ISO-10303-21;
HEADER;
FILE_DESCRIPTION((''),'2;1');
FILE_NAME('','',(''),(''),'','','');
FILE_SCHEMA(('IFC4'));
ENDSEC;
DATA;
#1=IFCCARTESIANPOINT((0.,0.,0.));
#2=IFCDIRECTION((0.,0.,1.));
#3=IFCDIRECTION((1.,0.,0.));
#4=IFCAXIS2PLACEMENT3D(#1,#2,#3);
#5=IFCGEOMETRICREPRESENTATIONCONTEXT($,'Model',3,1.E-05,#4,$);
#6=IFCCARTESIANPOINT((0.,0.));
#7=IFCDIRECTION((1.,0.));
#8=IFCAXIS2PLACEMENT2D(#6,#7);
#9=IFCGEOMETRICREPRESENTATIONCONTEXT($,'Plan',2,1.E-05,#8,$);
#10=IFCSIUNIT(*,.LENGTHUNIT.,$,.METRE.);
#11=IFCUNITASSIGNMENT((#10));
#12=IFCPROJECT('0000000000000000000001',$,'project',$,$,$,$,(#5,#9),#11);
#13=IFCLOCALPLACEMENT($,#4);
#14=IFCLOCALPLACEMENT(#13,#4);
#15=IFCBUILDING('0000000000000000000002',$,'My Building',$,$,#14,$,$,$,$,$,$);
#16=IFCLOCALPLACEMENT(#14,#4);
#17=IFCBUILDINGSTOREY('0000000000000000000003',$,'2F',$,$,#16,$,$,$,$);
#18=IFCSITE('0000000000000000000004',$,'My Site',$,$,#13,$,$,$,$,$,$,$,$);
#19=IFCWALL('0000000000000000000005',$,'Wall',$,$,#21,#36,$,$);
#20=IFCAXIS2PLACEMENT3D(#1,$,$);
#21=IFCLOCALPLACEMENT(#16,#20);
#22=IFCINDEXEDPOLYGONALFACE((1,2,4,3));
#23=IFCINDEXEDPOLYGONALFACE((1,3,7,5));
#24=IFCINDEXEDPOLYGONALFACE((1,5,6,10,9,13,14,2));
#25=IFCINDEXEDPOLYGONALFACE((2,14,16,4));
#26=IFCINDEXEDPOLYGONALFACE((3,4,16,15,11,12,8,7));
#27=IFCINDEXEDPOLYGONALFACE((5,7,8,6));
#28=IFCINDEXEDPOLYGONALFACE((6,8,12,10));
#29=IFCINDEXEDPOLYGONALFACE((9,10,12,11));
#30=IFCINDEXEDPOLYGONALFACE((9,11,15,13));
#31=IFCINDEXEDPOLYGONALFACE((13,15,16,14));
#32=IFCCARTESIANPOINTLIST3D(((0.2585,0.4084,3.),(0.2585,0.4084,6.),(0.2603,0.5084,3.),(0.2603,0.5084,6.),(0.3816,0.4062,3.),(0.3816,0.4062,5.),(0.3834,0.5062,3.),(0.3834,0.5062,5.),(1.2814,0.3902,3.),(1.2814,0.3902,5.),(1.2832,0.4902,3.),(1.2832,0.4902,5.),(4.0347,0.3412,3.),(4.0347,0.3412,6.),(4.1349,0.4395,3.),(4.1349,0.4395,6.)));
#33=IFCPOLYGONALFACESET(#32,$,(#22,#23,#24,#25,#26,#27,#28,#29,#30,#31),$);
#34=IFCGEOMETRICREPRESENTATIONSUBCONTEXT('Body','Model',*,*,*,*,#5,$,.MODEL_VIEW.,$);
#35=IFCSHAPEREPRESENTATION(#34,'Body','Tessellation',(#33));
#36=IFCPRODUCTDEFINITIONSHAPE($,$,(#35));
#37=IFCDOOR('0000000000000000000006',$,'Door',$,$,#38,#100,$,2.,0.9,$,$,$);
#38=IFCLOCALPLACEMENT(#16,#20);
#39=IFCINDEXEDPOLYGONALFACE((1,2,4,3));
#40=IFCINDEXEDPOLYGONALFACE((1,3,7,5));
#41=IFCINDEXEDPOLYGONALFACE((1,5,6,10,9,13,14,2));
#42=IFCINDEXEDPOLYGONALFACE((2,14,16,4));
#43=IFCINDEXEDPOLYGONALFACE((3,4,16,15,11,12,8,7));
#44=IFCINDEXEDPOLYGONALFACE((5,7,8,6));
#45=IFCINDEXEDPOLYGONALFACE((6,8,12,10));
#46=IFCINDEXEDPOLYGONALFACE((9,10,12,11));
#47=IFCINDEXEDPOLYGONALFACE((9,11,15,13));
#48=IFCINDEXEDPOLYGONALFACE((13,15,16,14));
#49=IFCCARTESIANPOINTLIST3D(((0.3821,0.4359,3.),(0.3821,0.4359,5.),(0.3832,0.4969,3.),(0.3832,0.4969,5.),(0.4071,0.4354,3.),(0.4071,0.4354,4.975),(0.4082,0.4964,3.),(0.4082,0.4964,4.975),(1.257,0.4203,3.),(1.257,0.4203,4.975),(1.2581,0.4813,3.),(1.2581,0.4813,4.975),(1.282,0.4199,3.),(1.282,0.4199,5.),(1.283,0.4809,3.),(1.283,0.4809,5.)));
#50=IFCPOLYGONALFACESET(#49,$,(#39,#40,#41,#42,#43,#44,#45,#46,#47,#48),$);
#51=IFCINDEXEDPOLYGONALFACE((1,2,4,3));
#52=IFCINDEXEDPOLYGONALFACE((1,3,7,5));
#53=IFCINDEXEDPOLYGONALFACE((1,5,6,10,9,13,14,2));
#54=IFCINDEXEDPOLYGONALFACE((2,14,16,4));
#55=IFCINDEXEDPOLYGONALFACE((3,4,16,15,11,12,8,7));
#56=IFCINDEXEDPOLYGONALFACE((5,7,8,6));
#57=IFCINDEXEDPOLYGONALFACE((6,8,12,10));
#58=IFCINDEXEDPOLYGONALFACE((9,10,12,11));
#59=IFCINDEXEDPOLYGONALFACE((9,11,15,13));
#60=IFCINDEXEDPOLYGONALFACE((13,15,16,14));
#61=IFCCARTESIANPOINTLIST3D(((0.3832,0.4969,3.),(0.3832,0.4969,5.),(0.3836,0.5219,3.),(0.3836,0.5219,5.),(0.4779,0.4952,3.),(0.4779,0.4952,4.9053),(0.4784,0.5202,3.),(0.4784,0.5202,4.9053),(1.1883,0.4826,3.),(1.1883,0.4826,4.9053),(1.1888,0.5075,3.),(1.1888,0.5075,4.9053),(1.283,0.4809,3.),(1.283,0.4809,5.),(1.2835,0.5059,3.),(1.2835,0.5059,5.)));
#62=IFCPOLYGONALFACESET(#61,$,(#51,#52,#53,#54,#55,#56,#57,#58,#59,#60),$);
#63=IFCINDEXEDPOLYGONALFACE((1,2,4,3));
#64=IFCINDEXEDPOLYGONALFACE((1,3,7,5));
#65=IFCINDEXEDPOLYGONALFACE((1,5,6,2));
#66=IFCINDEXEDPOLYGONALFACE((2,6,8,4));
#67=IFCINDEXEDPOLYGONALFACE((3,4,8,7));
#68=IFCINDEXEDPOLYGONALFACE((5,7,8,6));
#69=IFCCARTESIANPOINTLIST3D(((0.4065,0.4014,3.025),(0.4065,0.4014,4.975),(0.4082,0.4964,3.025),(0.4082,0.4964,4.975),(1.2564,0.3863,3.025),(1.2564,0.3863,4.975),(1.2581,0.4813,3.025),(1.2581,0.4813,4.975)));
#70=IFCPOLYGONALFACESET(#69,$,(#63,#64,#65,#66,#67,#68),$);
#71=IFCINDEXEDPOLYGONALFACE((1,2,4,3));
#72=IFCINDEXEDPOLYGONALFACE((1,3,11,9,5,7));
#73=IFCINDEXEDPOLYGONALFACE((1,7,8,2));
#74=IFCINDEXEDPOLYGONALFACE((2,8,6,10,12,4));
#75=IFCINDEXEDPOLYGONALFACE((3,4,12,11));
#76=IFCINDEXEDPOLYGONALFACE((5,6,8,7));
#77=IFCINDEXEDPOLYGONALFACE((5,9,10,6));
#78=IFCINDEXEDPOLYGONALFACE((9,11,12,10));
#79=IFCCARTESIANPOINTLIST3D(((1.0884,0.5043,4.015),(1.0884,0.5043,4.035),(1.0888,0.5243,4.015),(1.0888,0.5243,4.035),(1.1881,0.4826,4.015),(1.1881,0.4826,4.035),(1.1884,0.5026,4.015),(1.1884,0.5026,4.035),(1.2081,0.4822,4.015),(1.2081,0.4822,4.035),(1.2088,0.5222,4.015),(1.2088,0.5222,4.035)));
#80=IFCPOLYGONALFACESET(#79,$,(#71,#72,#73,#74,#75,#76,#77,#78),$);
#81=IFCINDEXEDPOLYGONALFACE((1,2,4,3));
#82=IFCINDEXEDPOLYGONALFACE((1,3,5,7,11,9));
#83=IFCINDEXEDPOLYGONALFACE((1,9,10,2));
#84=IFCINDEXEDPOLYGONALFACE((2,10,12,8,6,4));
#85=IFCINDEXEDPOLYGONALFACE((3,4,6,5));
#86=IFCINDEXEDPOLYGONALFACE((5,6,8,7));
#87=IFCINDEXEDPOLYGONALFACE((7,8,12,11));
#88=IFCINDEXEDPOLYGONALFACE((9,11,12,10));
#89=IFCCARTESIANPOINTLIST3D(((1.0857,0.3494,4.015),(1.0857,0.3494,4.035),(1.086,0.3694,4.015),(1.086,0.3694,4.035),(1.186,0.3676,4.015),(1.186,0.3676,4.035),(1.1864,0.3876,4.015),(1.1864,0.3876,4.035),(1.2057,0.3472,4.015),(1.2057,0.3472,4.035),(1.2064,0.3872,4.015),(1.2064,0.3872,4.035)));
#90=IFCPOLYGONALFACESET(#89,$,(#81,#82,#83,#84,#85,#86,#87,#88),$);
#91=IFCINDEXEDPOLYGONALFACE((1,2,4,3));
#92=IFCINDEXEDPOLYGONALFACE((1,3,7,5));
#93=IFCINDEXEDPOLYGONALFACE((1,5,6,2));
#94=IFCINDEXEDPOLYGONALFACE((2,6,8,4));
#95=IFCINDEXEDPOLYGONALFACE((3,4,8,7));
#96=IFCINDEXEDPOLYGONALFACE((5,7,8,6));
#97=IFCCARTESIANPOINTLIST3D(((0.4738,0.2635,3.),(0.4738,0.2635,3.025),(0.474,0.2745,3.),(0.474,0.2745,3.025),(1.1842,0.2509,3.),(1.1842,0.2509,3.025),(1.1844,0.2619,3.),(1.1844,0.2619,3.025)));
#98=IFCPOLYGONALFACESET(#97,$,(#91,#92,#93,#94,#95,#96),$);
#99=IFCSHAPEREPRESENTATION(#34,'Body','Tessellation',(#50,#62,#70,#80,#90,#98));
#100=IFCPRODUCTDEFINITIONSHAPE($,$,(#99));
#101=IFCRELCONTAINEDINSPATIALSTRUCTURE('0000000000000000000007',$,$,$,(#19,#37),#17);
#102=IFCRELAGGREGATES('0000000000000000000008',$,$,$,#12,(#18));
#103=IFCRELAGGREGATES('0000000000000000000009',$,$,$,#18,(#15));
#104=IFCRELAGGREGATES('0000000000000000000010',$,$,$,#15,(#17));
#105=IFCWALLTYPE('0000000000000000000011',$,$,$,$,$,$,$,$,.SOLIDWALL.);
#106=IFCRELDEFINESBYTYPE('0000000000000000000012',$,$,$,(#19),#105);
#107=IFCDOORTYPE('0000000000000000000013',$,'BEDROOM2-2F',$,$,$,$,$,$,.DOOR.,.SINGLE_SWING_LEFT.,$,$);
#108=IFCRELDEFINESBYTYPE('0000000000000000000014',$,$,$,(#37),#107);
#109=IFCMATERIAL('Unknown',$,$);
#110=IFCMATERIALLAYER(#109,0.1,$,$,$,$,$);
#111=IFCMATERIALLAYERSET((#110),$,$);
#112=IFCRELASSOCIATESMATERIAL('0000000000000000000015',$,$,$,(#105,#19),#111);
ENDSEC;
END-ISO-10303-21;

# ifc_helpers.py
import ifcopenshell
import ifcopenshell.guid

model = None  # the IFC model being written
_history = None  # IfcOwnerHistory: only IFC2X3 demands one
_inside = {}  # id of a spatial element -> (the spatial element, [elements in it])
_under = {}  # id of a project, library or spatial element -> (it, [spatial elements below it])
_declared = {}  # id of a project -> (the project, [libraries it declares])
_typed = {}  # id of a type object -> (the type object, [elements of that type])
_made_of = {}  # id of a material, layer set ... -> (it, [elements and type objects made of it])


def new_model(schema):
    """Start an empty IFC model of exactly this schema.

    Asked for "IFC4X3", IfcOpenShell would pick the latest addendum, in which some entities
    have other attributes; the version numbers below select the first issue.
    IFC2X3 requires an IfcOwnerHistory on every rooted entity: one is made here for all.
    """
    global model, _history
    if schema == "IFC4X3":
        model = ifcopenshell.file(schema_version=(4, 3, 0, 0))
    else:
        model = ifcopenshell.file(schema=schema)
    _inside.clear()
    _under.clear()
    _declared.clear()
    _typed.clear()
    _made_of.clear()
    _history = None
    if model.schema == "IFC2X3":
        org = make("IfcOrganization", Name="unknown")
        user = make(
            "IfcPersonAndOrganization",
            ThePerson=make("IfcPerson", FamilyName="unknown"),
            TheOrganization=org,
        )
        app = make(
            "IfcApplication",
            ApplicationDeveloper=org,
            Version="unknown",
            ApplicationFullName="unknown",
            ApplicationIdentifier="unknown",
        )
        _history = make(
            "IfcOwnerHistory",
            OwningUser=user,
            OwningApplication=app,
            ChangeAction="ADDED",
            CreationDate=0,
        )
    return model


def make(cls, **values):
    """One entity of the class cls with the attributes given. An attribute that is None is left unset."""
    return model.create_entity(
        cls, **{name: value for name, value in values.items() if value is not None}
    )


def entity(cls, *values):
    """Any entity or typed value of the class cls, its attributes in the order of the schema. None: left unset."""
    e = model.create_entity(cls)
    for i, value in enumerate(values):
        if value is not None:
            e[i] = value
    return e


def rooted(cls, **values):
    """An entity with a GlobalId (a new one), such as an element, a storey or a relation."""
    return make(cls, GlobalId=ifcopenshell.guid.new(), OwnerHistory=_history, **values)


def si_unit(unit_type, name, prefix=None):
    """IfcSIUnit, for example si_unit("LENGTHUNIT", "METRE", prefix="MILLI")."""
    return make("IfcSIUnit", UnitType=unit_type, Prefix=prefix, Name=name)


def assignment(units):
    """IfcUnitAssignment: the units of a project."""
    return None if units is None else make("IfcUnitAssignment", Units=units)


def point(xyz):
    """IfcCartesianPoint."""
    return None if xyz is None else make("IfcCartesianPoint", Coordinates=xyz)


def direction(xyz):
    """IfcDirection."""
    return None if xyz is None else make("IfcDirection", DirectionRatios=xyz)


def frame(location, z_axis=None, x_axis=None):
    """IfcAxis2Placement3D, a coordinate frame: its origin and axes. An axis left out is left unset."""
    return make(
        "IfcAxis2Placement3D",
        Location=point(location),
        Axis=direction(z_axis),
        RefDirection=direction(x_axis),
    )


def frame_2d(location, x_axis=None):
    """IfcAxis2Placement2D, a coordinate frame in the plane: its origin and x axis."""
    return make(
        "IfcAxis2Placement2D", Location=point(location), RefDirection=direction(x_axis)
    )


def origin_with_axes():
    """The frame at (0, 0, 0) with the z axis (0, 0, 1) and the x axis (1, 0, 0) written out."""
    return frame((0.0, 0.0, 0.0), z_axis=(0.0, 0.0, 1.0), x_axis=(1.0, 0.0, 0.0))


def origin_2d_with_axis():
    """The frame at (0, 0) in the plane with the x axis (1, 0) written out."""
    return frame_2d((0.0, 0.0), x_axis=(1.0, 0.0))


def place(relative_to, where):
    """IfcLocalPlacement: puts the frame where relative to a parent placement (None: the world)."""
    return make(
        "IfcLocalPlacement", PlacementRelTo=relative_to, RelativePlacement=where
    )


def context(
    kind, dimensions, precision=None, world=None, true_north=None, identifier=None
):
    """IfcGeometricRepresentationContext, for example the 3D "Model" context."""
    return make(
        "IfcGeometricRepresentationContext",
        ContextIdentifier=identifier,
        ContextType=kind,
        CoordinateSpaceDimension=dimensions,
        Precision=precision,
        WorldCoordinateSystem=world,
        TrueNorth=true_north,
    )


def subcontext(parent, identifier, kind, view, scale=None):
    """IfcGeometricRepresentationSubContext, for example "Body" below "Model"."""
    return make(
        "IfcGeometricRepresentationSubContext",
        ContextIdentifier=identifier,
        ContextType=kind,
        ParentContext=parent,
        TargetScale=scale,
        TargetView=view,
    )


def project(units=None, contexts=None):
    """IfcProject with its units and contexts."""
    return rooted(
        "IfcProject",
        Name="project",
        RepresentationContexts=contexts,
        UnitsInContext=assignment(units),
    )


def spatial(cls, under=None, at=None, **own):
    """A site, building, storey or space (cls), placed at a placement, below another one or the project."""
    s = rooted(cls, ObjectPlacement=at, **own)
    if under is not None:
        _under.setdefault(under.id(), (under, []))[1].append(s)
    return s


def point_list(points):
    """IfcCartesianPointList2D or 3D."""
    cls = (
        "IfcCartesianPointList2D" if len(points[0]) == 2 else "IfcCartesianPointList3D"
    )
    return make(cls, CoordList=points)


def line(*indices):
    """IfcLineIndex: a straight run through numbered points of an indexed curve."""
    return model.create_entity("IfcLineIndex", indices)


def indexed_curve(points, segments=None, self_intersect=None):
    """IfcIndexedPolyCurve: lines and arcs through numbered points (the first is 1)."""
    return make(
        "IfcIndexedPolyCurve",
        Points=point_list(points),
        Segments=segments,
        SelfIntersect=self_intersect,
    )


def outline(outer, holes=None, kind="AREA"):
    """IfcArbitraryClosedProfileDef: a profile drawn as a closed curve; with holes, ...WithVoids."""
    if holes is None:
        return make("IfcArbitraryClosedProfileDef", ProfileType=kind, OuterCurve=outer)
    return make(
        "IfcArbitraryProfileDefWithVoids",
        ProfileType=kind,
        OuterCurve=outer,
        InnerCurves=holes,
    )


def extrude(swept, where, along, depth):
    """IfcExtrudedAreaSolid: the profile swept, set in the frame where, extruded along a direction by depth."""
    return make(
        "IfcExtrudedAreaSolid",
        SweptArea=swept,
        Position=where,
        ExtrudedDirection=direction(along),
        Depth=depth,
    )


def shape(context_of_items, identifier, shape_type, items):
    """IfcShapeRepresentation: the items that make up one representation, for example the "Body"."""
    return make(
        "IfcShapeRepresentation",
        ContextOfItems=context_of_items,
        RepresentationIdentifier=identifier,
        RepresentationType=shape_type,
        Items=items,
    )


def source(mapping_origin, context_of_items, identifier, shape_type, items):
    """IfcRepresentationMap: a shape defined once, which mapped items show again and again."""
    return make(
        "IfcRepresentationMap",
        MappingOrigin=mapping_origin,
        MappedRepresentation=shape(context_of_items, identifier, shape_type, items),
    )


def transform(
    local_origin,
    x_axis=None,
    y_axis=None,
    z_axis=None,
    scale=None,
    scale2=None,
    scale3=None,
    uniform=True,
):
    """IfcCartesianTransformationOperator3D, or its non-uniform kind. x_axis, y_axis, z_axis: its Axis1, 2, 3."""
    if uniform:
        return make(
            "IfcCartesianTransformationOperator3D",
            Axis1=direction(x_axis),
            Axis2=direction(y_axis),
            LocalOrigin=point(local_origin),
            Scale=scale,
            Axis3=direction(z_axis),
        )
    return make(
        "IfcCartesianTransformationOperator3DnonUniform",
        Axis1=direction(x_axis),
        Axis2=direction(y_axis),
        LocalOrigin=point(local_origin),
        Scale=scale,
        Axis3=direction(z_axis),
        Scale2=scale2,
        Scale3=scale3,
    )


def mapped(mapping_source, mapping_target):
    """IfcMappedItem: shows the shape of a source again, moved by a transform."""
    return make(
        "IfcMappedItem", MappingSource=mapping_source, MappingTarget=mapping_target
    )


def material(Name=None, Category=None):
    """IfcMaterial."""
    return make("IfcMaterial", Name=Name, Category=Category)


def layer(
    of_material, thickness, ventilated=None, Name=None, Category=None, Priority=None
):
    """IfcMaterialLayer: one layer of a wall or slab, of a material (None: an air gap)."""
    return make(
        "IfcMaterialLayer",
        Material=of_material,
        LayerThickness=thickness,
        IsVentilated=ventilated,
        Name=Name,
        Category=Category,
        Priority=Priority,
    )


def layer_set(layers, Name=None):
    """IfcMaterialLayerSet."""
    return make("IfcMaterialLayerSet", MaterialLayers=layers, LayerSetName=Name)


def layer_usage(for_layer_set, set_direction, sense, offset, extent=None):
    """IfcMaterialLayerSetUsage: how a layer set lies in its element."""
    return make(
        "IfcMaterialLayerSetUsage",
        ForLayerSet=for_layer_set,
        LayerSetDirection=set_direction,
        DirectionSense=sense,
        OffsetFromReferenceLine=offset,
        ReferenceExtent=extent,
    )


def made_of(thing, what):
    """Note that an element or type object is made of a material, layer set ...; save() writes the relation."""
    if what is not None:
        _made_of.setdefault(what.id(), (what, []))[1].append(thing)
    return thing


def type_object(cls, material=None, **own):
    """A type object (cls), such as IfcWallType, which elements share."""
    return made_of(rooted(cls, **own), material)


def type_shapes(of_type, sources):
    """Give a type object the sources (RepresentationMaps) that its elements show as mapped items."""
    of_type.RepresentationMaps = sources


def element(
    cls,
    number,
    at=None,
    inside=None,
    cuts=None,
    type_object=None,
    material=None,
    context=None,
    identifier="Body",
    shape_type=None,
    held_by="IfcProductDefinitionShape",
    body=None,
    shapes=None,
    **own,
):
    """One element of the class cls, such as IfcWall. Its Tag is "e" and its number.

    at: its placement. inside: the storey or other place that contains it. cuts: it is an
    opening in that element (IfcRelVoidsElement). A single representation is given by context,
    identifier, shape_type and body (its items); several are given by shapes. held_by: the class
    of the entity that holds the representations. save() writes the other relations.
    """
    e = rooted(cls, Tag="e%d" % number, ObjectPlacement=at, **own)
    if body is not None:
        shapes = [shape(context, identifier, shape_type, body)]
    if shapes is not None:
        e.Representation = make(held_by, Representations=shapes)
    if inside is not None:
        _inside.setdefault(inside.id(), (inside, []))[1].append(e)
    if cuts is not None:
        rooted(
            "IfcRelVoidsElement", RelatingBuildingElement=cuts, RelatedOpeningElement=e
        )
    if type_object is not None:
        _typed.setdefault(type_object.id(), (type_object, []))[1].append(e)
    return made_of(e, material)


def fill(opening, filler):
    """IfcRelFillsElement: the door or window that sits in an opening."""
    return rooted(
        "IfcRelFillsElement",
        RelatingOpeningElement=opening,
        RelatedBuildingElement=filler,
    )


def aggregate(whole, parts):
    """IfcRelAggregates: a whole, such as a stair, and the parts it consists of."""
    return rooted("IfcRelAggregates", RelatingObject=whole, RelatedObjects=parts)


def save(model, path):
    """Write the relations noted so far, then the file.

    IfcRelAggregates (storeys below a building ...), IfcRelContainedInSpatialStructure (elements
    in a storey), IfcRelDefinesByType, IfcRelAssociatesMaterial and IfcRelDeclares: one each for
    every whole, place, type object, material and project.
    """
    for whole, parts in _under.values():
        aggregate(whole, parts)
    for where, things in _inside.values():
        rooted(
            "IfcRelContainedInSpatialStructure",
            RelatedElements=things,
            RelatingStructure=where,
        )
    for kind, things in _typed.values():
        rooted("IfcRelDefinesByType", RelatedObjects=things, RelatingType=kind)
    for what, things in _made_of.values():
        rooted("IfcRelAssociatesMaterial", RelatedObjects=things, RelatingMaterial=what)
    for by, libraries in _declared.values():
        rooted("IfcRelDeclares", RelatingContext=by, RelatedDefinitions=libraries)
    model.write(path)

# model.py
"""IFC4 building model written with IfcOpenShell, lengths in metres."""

from ifc_helpers import new_model, entity, si_unit, frame, origin_with_axes, origin_2d_with_axis, place, context, subcontext, project, spatial, line, indexed_curve, outline, extrude, shape, source, transform, mapped, material, layer, layer_set, layer_usage, type_object, type_shapes, element, fill, save


model = new_model("IFC4")

# Units and contexts
model_context = context("Model", 3, precision=1e-05, world=origin_with_axes())
plan_context = context("Plan", 2, precision=1e-05, world=origin_2d_with_axis())
body_context_1 = subcontext(model_context, "Body", "Model", "MODEL_VIEW")
body_context_2 = subcontext(plan_context, "Body", "Plan", "PLAN_VIEW")
ifc_project = project(units=[si_unit("LENGTHUNIT", "METRE")], contexts=[model_context, plan_context])

# Site, building, storey
site_placement = place(None, origin_with_axes())
site = spatial("IfcSite", under=ifc_project, at=site_placement, Name="My Site")
building_placement = place(site_placement, origin_with_axes())
building = spatial("IfcBuilding", under=site, at=building_placement, Name="My Building")
storey_placement = place(building_placement, origin_with_axes())
storey = spatial("IfcBuildingStorey", under=building, at=storey_placement, Name="2F")

# Shared definitions
ifc_material = material(Name="Unknown")

# Wall, opening, door
ifc_layer_1 = layer(ifc_material, 0.1)
ifc_layer_set_1 = layer_set([ifc_layer_1])
wall_type_1 = type_object("IfcWallType", PredefinedType="SOLIDWALL", material=ifc_layer_set_1)
ifc_layer_usage_1 = layer_usage(ifc_layer_set_1, "AXIS2", "POSITIVE", 0.0)
wall_1_placement = place(storey_placement, frame((0.2585, 0.4084, 3.0), z_axis=(0.0, 0.0, 1.0), x_axis=(0.999842, -0.017775, 0.0)))
wall_1 = element("IfcWall", 1, at=wall_1_placement, inside=storey, type_object=wall_type_1, material=ifc_layer_usage_1, Name="Wall", context=body_context_1, shape_type="SweptSolid", body=[
    extrude(outline(indexed_curve([(0.0, 0.0), (0.0, 0.1), (3.8752, 0.1), (3.7768, 0.0)], segments=[line(1, 2, 3, 4, 1)])), origin_with_axes(), (0.0, 0.0, 1.0), 3.0),
])
shared_shape_1 = source(origin_with_axes(), body_context_1, "Body", "SweptSolid", [
    extrude(outline(indexed_curve([(0.0, 0.0), (0.9, 0.0), (0.9, 2.0), (0.0, 2.0)], segments=[line(1, 2, 3, 4, 1)])), frame((0.0, -0.6, 0.0), z_axis=(0.0, -1.0, 0.0), x_axis=(1.0, 0.0, 0.0)), (0.0, 0.0, -1.0), 1.2),
])
opening_1_placement = place(wall_1_placement, frame((1.0231, 0.1, 0.0), z_axis=(0.0, 0.0, 1.0), x_axis=(-1.0, 0.0, 0.0)))
opening_1 = element("IfcOpeningElement", 2, at=opening_1_placement, cuts=wall_1, PredefinedType="OPENING", context=body_context_1, shape_type="MappedRepresentation", body=[
    mapped(shared_shape_1, transform((0.0, 0.0, 0.0), x_axis=(1.0, 0.0, 0.0), y_axis=(0.0, 1.0, 0.0), z_axis=(0.0, 0.0, 1.0), scale=1.0)),
])
door_type_1 = type_object("IfcDoorType", Name="BEDROOM2-2F", OperationType="SINGLE_SWING_LEFT", PredefinedType="DOOR")
shared_shape_2 = source(origin_with_axes(), body_context_1, "Body", "SweptSolid", [
    extrude(outline(indexed_curve([(0.0, 0.0), (0.0, 2.0), (0.9, 2.0), (0.9, 0.0), (0.875, 0.0), (0.875, 1.975), (0.025, 1.975), (0.025, 0.0)], segments=[line(1, 2, 3, 4, 5, 6, 7, 8, 1)])), frame((0.0, 0.0093, 0.0), z_axis=(0.0, -1.0, 0.0), x_axis=(1.0, 0.0, 0.0)), (0.0, 0.0, -1.0), 0.061),
    extrude(outline(indexed_curve([(0.0, 0.0), (0.0, 2.0), (0.9, 2.0), (0.9, 0.0), (0.8053, 0.0), (0.8053, 1.9053), (0.0947, 1.9053), (0.0947, 0.0)], segments=[line(1, 2, 3, 4, 5, 6, 7, 8, 1)])), frame((0.0, -0.0157, 0.0), z_axis=(0.0, -1.0, 0.0), x_axis=(1.0, 0.0, 0.0)), (0.0, 0.0, -1.0), 0.025),
    extrude(outline(indexed_curve([(0.0, 0.0), (0.85, 0.0), (0.85, 0.095), (0.0, 0.095)], segments=[line(1, 2, 3, 4, 1)])), frame((0.025, 0.0093, 0.025), z_axis=(0.0, 0.0, 1.0), x_axis=(1.0, 0.0, 0.0)), (0.0, 0.0, 1.0), 1.95),
    extrude(outline(indexed_curve([(0.0, 0.0), (0.0, -0.04), (0.12, -0.04), (0.12, -0.02), (0.02, -0.02), (0.02, 0.0)], segments=[line(1, 2, 3, 4, 5, 6, 1)])), frame((0.075, 0.0093, 1.015), z_axis=(0.0, 0.0, 1.0), x_axis=(1.0, 0.0, 0.0)), (0.0, 0.0, 1.0), 0.02),
    extrude(outline(indexed_curve([(0.0, 0.0), (0.0, 0.04), (0.12, 0.04), (0.12, 0.02), (0.02, 0.02), (0.02, 0.0)], segments=[line(1, 2, 3, 4, 5, 6, 1)])), frame((0.075, 0.1043, 1.015), z_axis=(0.0, 0.0, 1.0), x_axis=(1.0, 0.0, 0.0)), (0.0, 0.0, 1.0), 0.02),
    extrude(outline(indexed_curve([(0.0, 0.0), (0.7105, 0.0), (0.7105, 0.011), (0.0, 0.011)], segments=[line(1, 2, 3, 4, 1)])), frame((0.0947, 0.23, 0.0), z_axis=(0.0, 0.0, 1.0), x_axis=(1.0, 0.0, 0.0)), (0.0, 0.0, 1.0), 0.025),
])
shared_shape_3 = source(origin_with_axes(), body_context_2, "Body", "Curve2D", [
    entity("IfcIndexedPolyCurve", entity("IfcCartesianPointList2D", [[0.0, -0.0157], [0.0, 0.0703], [0.025, 0.0703], [0.025, 0.0093], [0.0947, 0.0093], [0.0947, -0.0157]]), [entity("IfcLineIndex", [1, 2, 3, 4, 5, 6, 1])]),
    entity("IfcIndexedPolyCurve", entity("IfcCartesianPointList2D", [[0.9, -0.0157], [0.9, 0.0703], [0.875, 0.0703], [0.875, 0.0093], [0.8053, 0.0093], [0.8053, -0.0157]]), [entity("IfcLineIndex", [1, 2, 3, 4, 5, 6, 1])]),
    entity("IfcTrimmedCurve", entity("IfcEllipse", entity("IfcAxis2Placement2D", entity("IfcCartesianPoint", [0.78, 0.0703]), entity("IfcDirection", [1.0, 0.0])), 0.755, 0.85), [entity("IfcCartesianPoint", [0.78, 0.9203])], [entity("IfcCartesianPoint", [0.025, 0.0703])], True, "CARTESIAN"),
    entity("IfcIndexedPolyCurve", entity("IfcCartesianPointList2D", [[0.875, 0.0703], [0.78, 0.0703], [0.78, 0.9203], [0.875, 0.9203]]), [entity("IfcLineIndex", [1, 2, 3, 4, 1])]),
])
type_shapes(door_type_1, [shared_shape_2, shared_shape_3])
door_1_placement = place(opening_1_placement, frame((0.0, 0.0, 0.0), z_axis=(0.0, 0.0, 1.0), x_axis=(1.0, 0.0, 0.0)))
door_1 = element("IfcDoor", 3, at=door_1_placement, inside=storey, type_object=door_type_1, Name="Door", OverallHeight=2.0, OverallWidth=0.9, shapes=[
    shape(body_context_1, "Body", "MappedRepresentation", [mapped(shared_shape_2, transform((0.0, 0.0, 0.0), x_axis=(1.0, 0.0, 0.0), y_axis=(0.0, 1.0, 0.0), z_axis=(0.0, 0.0, 1.0), scale=1.0))]),
    shape(body_context_2, "Body", "MappedRepresentation", [mapped(shared_shape_3, transform((0.0, 0.0, 0.0), x_axis=(1.0, 0.0, 0.0), y_axis=(0.0, 1.0, 0.0), z_axis=(0.0, 0.0, 1.0), scale=1.0))]),
])
fill(opening_1, door_1)

save(model, "model.ifc")
